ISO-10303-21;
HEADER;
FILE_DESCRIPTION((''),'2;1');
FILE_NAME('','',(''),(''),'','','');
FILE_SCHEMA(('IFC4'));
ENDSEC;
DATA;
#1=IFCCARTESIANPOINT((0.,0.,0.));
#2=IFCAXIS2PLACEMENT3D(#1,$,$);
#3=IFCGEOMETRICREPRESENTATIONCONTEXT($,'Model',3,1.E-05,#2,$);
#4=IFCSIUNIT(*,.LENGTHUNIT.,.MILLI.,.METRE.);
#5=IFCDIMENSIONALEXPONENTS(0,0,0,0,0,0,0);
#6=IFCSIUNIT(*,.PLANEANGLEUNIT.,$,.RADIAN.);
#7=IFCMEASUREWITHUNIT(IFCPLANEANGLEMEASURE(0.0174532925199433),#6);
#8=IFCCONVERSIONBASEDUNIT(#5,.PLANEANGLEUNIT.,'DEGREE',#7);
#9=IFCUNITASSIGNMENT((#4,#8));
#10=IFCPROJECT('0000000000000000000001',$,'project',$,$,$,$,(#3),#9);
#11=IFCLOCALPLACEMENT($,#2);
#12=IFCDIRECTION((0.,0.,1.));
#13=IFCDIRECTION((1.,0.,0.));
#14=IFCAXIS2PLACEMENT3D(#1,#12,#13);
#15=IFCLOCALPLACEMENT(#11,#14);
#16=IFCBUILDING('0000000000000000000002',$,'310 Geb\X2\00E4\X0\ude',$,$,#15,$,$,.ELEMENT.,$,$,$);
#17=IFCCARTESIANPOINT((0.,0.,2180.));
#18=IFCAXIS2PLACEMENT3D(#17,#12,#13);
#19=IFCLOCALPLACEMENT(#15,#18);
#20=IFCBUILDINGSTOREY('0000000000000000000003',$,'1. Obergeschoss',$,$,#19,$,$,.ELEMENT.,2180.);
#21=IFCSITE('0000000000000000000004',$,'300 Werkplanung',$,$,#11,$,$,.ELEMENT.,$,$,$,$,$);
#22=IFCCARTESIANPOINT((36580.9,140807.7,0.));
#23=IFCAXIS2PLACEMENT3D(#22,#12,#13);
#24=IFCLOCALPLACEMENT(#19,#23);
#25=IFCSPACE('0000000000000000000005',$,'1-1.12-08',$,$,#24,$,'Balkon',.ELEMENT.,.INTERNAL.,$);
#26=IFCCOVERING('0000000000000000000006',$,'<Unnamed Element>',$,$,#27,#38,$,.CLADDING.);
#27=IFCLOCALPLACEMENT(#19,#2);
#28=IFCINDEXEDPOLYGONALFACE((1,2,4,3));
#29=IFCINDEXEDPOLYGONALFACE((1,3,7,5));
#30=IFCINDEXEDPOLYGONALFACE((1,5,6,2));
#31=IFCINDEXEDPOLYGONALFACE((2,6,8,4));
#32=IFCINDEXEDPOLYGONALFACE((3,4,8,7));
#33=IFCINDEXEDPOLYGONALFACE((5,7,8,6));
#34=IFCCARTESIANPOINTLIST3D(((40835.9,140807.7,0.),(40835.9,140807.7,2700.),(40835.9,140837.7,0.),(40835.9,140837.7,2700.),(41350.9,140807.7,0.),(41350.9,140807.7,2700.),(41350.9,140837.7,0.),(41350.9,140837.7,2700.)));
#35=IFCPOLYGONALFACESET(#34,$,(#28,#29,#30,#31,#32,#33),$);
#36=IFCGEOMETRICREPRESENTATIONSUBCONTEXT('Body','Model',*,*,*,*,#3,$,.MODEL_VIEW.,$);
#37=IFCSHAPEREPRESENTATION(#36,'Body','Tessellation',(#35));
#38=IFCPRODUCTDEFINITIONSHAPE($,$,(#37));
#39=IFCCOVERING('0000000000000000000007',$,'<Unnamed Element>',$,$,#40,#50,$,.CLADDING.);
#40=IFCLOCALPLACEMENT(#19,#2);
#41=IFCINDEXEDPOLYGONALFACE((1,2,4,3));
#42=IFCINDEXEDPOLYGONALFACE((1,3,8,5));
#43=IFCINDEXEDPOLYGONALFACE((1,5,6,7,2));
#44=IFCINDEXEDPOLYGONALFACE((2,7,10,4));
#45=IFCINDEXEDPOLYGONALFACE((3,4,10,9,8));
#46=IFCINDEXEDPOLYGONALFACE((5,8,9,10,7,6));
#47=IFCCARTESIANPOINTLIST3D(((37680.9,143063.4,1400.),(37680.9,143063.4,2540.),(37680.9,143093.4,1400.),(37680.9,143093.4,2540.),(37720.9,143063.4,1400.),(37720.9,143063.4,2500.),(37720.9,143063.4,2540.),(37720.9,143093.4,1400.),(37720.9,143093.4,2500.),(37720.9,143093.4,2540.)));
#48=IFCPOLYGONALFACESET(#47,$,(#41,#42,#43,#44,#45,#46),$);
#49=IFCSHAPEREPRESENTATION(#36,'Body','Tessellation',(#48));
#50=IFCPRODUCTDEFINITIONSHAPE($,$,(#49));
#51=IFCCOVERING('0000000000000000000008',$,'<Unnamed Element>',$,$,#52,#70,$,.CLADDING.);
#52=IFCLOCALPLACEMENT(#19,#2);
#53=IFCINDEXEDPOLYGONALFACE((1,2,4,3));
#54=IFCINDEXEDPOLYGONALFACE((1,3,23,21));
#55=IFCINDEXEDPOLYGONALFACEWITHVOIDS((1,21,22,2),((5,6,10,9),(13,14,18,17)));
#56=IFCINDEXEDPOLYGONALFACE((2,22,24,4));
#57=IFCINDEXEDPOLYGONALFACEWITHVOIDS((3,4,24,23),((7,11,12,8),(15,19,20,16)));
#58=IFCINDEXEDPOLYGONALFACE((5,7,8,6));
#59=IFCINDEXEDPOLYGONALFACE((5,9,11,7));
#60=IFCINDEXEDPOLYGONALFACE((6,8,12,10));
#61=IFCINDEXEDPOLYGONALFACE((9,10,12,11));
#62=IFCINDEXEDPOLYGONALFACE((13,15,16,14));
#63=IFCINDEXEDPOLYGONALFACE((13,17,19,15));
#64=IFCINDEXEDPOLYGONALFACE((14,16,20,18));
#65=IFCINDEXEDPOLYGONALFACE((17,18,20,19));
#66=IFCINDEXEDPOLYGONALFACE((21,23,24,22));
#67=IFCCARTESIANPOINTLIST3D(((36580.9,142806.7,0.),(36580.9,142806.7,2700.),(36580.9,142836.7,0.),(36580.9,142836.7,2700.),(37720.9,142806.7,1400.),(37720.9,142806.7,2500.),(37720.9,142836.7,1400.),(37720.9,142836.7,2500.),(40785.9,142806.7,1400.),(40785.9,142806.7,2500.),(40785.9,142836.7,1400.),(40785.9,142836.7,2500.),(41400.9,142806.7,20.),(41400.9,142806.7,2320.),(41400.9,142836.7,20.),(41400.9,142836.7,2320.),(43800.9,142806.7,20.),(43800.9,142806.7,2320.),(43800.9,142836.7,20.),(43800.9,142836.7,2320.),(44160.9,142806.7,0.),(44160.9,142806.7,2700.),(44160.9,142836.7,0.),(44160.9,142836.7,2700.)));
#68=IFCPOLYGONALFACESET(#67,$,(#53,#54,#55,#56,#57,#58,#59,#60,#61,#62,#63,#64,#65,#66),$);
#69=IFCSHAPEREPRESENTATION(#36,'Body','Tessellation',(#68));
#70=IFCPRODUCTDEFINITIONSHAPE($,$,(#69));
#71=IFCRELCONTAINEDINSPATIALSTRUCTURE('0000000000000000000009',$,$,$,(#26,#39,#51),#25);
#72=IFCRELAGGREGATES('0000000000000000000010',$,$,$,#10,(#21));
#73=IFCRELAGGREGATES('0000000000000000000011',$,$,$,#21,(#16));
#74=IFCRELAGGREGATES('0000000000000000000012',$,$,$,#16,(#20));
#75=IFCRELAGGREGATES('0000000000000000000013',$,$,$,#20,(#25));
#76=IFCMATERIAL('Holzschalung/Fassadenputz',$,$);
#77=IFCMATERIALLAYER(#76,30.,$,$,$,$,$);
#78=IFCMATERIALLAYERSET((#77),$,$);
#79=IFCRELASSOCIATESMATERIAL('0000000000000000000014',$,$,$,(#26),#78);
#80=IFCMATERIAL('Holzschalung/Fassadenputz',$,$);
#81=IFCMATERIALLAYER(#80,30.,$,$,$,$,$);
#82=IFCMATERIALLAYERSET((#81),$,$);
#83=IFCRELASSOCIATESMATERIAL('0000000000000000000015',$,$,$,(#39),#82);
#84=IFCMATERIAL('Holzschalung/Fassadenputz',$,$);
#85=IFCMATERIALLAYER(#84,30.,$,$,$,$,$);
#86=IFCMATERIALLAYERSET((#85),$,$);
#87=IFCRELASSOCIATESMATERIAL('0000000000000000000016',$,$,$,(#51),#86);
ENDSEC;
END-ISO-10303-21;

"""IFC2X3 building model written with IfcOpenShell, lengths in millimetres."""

from ifc_helpers import new_model, entity, si_unit, converted_unit, frame, frame_2d, origin, origin_with_axes, place, context, subcontext, project, spatial, polyline, rectangle, outline, extrude, material, layer, layer_set, layer_usage, element, save


model = new_model("IFC2X3")

# Units and contexts
model_context = context("Model", 3, precision=1e-05, world=origin())
body_context = subcontext(model_context, "Body", "Model", "MODEL_VIEW")
ifc_project = project(units=[si_unit("LENGTHUNIT", "METRE", prefix="MILLI"), converted_unit("PLANEANGLEUNIT", "DEGREE", entity("IfcPlaneAngleMeasure", 0.0174532925199433), si_unit("PLANEANGLEUNIT", "RADIAN"), dimensions=[0, 0, 0, 0, 0, 0, 0])], contexts=[model_context])

# Site, building, storey
site_placement = place(None, origin())
site = spatial("IfcSite", under=ifc_project, at=site_placement, Name="300 Werkplanung", CompositionType="ELEMENT")
building_placement = place(site_placement, origin_with_axes())
building = spatial("IfcBuilding", under=site, at=building_placement, Name="310 Gebäude", CompositionType="ELEMENT")
storey_placement = place(building_placement, frame((0.0, 0.0, 2180.0), z_axis=(0.0, 0.0, 1.0), x_axis=(1.0, 0.0, 0.0)))
storey = spatial("IfcBuildingStorey", under=building, at=storey_placement, Name="1. Obergeschoss", CompositionType="ELEMENT", Elevation=2180.0)

# Shared definitions
space_1_placement = place(storey_placement, frame((36580.9, 140807.7, 0.0), z_axis=(0.0, 0.0, 1.0), x_axis=(1.0, 0.0, 0.0)))
space_1 = spatial("IfcSpace", under=storey, at=space_1_placement, Name="1-1.12-08", LongName="Balkon", CompositionType="ELEMENT", InteriorOrExteriorSpace="INTERNAL")

# Coverings
ifc_material_1 = material(Name="Holzschalung/Fassadenputz")
ifc_layer_1 = layer(ifc_material_1, 30.0)
ifc_layer_set_1 = layer_set([ifc_layer_1])
ifc_layer_usage_1 = layer_usage(ifc_layer_set_1, "AXIS3", "POSITIVE", 0.0)
covering_1_placement = place(space_1_placement, frame((4255.0, 0.0, 0.0), z_axis=(0.0, 0.0, 1.0), x_axis=(1.0, 0.0, 0.0)))
element("IfcCovering", 1, at=covering_1_placement, inside=space_1, material=ifc_layer_usage_1, Name="<Unnamed Element>", PredefinedType="CLADDING", context=body_context, shape_type="SweptSolid", body=[
    extrude(rectangle(XDim=515.0, YDim=2700.0, at=frame_2d((-257.5, -1350.0), x_axis=(-1.0, 0.0))), frame((515.0, 0.0, 0.0), z_axis=(0.0, 1.0, 0.0), x_axis=(1.0, 0.0, 0.0)), (0.0, 0.0, 1.0), 30.0),
])
ifc_material_2 = material(Name="Holzschalung/Fassadenputz")
ifc_layer_2 = layer(ifc_material_2, 30.0)
ifc_layer_set_2 = layer_set([ifc_layer_2])
ifc_layer_usage_2 = layer_usage(ifc_layer_set_2, "AXIS3", "POSITIVE", 0.0)
covering_2_placement = place(space_1_placement, frame((1100.0, 2255.7, 1400.0), z_axis=(0.0, 0.0, 1.0), x_axis=(1.0, 0.0, 0.0)))
element("IfcCovering", 2, at=covering_2_placement, inside=space_1, material=ifc_layer_usage_2, Name="<Unnamed Element>", PredefinedType="CLADDING", context=body_context, shape_type="SweptSolid", body=[
    extrude(outline(polyline([(0.0, 0.0), (40.0, 0.0), (40.0, -1100.0), (40.0, -1140.0), (0.0, -1140.0), (0.0, 0.0)])), frame((0.0, 0.0, 0.0), z_axis=(0.0, 1.0, 0.0), x_axis=(1.0, 0.0, 0.0)), (0.0, 0.0, 1.0), 30.0),
])
ifc_material_3 = material(Name="Holzschalung/Fassadenputz")
ifc_layer_3 = layer(ifc_material_3, 30.0)
ifc_layer_set_3 = layer_set([ifc_layer_3])
ifc_layer_usage_3 = layer_usage(ifc_layer_set_3, "AXIS3", "POSITIVE", 0.0)
covering_3_placement = place(space_1_placement, frame((7580.0, 2029.0, 0.0), z_axis=(0.0, 0.0, 1.0), x_axis=(-1.0, 0.0, 0.0)))
element("IfcCovering", 3, at=covering_3_placement, inside=space_1, material=ifc_layer_usage_3, Name="<Unnamed Element>", PredefinedType="CLADDING", context=body_context, shape_type="SweptSolid", body=[
    extrude(outline(polyline([(0.0, 0.0), (7580.0, 0.0), (7580.0, -2700.0), (0.0, -2700.0), (0.0, 0.0)]), holes=[polyline([(2760.0, -20.0), (360.0, -20.0), (360.0, -2320.0), (2760.0, -2320.0), (2760.0, -20.0)]), polyline([(6440.0, -1400.0), (3375.0, -1400.0), (3375.0, -2500.0), (6440.0, -2500.0), (6440.0, -1400.0)])]), frame((0.0, 0.0, 0.0), z_axis=(0.0, 1.0, 0.0), x_axis=(1.0, 0.0, 0.0)), (0.0, 0.0, 1.0), 30.0),
])

save(model, "model.ifc")
